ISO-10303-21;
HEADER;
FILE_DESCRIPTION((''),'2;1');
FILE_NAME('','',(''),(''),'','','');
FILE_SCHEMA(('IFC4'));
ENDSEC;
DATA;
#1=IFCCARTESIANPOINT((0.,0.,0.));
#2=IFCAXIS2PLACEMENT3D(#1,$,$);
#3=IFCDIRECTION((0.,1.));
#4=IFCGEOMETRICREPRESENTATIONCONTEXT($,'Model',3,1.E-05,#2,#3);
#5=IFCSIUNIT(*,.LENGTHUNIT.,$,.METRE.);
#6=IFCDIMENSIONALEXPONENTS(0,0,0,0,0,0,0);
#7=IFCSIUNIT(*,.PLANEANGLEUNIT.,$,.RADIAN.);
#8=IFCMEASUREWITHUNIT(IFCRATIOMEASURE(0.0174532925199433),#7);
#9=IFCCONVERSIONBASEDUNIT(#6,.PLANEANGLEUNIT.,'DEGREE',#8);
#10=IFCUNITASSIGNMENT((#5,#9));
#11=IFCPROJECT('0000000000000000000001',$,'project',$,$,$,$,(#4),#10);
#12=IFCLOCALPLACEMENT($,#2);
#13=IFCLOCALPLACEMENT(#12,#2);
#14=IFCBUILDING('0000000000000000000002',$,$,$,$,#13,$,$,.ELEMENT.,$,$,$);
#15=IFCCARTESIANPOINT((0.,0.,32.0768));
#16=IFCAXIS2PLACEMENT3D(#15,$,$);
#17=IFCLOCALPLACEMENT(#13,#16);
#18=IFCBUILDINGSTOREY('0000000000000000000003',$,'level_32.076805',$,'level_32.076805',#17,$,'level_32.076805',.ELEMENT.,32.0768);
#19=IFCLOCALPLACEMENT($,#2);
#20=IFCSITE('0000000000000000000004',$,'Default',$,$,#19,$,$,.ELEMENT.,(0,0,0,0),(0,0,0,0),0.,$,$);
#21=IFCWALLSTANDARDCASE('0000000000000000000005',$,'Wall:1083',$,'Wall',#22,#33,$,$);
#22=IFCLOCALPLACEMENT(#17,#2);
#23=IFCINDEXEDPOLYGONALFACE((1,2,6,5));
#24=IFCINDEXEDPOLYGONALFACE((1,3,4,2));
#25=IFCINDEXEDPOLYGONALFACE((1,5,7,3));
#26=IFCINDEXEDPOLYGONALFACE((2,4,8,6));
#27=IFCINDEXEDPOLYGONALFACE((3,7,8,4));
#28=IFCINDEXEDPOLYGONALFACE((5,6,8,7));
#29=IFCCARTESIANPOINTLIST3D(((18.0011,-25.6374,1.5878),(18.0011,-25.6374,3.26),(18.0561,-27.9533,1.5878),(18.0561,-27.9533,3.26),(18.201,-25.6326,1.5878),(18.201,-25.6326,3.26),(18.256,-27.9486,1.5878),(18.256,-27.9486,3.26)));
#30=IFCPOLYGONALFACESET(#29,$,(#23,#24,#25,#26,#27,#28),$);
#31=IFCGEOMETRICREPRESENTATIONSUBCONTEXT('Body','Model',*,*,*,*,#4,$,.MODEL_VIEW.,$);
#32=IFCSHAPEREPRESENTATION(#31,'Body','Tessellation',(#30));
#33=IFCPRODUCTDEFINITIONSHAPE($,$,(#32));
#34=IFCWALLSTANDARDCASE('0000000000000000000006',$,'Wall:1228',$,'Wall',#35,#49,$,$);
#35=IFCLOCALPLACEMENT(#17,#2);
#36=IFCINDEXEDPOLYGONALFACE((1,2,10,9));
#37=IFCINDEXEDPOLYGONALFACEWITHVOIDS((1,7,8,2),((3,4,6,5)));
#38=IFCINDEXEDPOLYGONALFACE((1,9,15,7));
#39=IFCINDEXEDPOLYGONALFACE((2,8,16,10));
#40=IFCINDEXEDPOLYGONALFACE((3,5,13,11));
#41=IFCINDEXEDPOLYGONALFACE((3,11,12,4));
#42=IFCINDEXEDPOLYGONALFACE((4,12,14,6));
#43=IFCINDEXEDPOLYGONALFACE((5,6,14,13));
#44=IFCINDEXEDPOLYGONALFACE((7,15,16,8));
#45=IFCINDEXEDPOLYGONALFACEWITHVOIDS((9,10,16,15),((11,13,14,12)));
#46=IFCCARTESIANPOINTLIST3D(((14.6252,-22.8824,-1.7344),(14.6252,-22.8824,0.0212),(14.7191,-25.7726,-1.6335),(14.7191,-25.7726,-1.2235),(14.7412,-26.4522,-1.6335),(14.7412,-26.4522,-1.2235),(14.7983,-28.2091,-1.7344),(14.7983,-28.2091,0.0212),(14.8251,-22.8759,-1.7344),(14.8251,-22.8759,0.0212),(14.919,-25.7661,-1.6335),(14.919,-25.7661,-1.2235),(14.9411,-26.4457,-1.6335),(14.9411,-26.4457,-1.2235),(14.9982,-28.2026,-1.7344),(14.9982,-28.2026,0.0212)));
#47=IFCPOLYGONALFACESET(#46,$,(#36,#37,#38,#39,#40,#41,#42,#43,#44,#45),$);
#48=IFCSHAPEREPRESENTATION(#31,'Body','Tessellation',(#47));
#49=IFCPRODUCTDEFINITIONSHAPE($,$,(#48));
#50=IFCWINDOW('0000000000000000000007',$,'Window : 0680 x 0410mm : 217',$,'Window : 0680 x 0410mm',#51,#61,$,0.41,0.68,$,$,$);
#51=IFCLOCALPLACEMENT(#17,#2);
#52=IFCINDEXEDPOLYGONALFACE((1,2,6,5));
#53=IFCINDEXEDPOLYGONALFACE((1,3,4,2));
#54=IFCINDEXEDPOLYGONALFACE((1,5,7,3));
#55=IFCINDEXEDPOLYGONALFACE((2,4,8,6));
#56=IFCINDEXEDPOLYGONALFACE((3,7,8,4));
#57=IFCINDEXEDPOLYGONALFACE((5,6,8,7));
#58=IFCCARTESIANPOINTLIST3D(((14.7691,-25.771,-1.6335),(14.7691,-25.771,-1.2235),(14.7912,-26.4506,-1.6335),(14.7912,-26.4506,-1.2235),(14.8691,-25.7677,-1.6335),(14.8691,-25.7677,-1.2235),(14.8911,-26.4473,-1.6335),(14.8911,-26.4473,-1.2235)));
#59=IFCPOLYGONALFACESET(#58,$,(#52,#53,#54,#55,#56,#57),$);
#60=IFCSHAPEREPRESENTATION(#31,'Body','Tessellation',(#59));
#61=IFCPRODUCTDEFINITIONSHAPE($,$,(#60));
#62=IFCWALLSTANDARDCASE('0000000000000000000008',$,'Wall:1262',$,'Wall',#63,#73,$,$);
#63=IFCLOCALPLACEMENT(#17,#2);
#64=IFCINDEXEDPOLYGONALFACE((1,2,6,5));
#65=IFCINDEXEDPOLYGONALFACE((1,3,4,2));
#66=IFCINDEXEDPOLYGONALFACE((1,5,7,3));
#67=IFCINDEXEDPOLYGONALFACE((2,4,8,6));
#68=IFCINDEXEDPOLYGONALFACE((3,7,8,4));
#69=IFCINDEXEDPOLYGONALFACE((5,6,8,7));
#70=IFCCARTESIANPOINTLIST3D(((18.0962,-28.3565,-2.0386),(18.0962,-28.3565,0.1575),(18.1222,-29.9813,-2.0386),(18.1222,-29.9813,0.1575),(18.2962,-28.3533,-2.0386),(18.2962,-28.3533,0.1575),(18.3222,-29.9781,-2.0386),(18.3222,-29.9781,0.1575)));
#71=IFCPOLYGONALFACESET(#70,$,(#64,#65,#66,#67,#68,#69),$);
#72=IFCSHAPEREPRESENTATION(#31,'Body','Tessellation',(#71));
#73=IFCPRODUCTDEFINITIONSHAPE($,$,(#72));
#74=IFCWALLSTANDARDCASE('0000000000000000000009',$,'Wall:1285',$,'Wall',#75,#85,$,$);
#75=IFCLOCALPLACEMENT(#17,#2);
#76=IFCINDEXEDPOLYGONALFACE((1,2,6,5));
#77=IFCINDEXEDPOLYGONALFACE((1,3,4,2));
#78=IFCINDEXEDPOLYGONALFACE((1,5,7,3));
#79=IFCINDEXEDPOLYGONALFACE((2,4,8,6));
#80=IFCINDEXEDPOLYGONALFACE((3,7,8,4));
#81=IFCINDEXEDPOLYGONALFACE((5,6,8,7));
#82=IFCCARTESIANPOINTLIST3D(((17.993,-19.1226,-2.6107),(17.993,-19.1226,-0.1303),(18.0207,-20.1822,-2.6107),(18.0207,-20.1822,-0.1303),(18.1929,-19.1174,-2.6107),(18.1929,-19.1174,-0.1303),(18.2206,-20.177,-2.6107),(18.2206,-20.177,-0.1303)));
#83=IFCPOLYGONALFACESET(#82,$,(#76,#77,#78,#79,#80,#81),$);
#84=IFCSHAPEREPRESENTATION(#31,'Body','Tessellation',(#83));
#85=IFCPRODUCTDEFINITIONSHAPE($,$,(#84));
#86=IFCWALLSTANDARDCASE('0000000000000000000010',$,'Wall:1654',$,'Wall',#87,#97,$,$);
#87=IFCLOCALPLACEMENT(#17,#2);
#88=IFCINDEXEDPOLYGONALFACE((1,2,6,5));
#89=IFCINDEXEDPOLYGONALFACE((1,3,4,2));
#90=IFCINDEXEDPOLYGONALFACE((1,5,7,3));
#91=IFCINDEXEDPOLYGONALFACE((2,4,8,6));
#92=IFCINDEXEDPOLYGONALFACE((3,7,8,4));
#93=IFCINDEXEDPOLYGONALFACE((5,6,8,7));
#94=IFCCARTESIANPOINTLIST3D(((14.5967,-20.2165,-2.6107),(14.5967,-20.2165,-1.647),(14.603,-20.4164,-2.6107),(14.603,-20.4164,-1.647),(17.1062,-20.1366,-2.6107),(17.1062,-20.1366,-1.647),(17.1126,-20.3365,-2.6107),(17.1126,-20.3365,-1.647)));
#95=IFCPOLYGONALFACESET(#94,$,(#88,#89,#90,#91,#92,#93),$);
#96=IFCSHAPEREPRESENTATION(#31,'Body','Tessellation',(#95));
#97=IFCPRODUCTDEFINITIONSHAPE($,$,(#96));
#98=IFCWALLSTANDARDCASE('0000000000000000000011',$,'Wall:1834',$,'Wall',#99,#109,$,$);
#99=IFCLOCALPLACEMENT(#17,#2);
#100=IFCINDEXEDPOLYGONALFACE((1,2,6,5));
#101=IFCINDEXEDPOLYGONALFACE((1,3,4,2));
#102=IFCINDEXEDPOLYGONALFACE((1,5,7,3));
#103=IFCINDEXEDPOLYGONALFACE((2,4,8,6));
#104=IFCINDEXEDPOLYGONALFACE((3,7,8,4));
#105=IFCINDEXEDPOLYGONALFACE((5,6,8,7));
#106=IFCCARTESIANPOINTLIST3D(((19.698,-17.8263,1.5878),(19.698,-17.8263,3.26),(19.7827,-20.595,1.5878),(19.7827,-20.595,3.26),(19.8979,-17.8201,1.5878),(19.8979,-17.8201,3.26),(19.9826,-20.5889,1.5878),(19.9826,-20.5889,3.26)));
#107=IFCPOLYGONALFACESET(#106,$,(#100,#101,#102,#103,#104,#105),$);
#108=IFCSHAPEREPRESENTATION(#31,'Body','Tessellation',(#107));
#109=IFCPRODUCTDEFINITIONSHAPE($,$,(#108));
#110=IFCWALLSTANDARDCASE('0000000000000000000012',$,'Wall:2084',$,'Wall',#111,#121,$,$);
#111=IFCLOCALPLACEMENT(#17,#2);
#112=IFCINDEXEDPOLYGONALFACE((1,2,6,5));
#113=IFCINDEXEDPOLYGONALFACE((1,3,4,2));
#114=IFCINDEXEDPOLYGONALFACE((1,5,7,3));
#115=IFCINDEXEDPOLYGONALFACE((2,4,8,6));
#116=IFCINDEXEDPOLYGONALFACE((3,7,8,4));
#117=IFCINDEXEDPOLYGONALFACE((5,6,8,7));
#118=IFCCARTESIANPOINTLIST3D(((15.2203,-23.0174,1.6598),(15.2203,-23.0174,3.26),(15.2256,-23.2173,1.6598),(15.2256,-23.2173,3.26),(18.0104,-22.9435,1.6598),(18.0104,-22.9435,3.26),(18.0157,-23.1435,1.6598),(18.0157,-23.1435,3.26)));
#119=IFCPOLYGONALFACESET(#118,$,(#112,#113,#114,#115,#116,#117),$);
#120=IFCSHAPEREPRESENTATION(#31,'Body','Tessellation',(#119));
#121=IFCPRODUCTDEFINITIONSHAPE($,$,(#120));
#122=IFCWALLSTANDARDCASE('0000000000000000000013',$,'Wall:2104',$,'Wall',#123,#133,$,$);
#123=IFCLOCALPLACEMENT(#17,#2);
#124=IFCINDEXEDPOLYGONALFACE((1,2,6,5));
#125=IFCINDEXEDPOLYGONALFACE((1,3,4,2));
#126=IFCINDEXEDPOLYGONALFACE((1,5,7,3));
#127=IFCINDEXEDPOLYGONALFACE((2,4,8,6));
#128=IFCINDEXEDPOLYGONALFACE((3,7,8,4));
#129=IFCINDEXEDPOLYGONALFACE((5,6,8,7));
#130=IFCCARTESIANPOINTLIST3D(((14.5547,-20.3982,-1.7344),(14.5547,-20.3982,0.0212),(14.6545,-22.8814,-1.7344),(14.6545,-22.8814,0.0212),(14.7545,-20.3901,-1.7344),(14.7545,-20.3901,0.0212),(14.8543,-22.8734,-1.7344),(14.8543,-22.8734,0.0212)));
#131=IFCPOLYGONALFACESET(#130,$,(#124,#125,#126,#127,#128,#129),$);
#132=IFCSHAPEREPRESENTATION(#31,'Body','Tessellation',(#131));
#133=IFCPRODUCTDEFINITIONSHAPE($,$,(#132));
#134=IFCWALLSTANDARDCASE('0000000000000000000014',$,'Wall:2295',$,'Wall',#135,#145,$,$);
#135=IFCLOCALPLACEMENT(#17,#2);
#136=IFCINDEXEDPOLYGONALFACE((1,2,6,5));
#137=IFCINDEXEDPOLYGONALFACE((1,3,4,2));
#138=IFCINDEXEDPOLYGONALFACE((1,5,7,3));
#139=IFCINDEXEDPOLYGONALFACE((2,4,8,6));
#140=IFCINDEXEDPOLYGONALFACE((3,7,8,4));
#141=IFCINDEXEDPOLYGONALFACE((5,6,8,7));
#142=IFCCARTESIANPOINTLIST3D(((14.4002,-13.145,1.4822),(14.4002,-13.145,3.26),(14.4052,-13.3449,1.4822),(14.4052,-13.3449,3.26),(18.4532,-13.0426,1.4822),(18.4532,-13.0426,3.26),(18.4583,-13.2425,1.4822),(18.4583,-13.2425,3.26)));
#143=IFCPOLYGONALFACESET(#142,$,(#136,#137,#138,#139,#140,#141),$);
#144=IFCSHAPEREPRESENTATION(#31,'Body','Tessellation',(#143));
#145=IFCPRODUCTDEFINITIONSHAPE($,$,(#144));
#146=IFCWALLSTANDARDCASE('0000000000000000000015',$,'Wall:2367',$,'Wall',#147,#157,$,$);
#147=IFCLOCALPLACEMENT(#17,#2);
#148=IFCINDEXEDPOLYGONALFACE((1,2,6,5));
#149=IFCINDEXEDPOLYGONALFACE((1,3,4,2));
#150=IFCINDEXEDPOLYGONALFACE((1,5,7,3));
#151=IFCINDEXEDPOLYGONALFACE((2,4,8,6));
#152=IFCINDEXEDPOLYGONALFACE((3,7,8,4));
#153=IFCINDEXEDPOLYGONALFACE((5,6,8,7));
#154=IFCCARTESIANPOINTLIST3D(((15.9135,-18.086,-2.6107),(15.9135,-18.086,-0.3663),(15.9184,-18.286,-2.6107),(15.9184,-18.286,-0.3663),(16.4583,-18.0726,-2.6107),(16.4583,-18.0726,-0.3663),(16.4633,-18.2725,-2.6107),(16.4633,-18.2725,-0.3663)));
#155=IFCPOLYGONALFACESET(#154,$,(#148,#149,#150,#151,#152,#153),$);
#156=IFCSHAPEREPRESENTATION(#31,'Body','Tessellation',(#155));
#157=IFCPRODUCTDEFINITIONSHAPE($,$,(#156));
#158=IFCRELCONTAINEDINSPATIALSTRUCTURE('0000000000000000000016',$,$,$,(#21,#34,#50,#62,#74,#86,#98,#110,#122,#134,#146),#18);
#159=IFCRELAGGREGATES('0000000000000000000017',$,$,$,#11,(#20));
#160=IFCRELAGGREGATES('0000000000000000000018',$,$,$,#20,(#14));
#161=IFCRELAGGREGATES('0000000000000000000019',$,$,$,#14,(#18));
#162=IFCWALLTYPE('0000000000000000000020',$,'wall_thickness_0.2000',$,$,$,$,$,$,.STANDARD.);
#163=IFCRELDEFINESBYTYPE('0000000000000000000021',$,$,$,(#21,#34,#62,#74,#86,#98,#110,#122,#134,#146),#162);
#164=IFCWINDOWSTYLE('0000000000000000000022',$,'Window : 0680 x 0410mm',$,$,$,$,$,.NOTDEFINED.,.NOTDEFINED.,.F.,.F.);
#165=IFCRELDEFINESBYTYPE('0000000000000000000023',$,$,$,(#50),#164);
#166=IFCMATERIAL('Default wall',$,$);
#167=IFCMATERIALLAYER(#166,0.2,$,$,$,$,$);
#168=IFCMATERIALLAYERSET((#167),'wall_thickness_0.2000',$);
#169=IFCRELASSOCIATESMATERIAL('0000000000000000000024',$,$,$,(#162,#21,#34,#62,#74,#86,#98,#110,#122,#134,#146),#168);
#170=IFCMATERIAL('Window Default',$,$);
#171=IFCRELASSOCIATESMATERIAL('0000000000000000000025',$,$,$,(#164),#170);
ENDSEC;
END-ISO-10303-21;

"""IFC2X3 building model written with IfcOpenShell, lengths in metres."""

from ifc_helpers import new_model, entity, si_unit, converted_unit, direction, frame, frame_2d, origin, origin_2d_with_axis, place, context, subcontext, project, spatial, polyline, rectangle, outline, extrude, source, transform, mapped, material, layer, layer_set, layer_usage, type_object, type_shapes, element, fill, save


model = new_model("IFC2X3")

# Units and contexts
model_context = context("Model", 3, precision=1e-05, world=origin(), true_north=direction((0.0, 1.0)))
body_context = subcontext(model_context, "Body", "Model", "MODEL_VIEW")
ifc_project = project(units=[si_unit("LENGTHUNIT", "METRE"), converted_unit("PLANEANGLEUNIT", "DEGREE", entity("IfcRatioMeasure", 0.0174532925199433), si_unit("PLANEANGLEUNIT", "RADIAN"), dimensions=[0, 0, 0, 0, 0, 0, 0])], contexts=[model_context])

# Site, building, storey
site_placement = place(None, origin())
site = spatial("IfcSite", under=ifc_project, at=site_placement, Name="Default", CompositionType="ELEMENT", RefLatitude=(0, 0, 0, 0), RefLongitude=(0, 0, 0, 0), RefElevation=0.0)
placement_1 = place(None, origin())
building_placement = place(placement_1, origin())
building = spatial("IfcBuilding", under=site, at=building_placement, CompositionType="ELEMENT")
storey_placement = place(building_placement, frame((0.0, 0.0, 32.0768)))
storey = spatial("IfcBuildingStorey", under=building, at=storey_placement, Name="level_32.076805", ObjectType="level_32.076805", LongName="level_32.076805", CompositionType="ELEMENT", Elevation=32.0768)

# Shared definitions
ifc_material_1 = material(Name="Default wall")
ifc_layer = layer(ifc_material_1, 0.2)
ifc_layer_set = layer_set([ifc_layer], Name="wall_thickness_0.2000")
ifc_layer_usage = layer_usage(ifc_layer_set, "AXIS2", "POSITIVE", -0.1)
wall_type = type_object("IfcWallType", Name="wall_thickness_0.2000", PredefinedType="STANDARD", material=ifc_layer_set)

# Shared definitions
ifc_material_2 = material(Name="Window Default")

# Wall
placement_2 = place(building_placement, frame((0.0, 0.0, 33.6646)))
wall_1_placement = place(placement_2, frame((18.156, -27.9509, 0.0), z_axis=(0.0, 0.0, 1.0), x_axis=(-0.02373, 0.999718, 0.0)))
element("IfcWallStandardCase", 1, at=wall_1_placement, inside=storey, type_object=wall_type, material=ifc_layer_usage, Name="Wall:1083", ObjectType="Wall", context=body_context, shape_type="SweptSolid", body=[
    extrude(outline(polyline([(2.3166, -0.1), (2.3166, 0.1), (0.0, 0.1), (0.0, -0.1), (2.3166, -0.1)])), origin(), (0.0, 0.0, 1.0), 1.6722),
])

# Wall, opening, window
placement_3 = place(building_placement, frame((0.0, 0.0, 30.3424)))
wall_2_placement = place(placement_3, frame((14.8983, -28.2059, 0.0), z_axis=(0.0, 0.0, 1.0), x_axis=(-0.032478, 0.999472, 0.0)))
wall_2 = element("IfcWallStandardCase", 2, at=wall_2_placement, inside=storey, type_object=wall_type, material=ifc_layer_usage, Name="Wall:1228", ObjectType="Wall", context=body_context, shape_type="SweptSolid", body=[
    extrude(outline(polyline([(5.3296, -0.1), (5.3296, 0.1), (0.0, 0.1), (0.0, -0.1), (5.3296, -0.1)])), origin(), (0.0, 0.0, 1.0), 1.7557),
])
opening_1_placement = place(wall_2_placement, frame((1.7578, -0.1, 0.1009)))
opening_1 = element("IfcOpeningElement", 3, at=opening_1_placement, cuts=wall_2, ObjectType="Opening", context=body_context, shape_type="SweptSolid", body=[
    extrude(rectangle(XDim=0.68, YDim=0.41, at=frame_2d((0.205, 0.34), x_axis=(0.0, 1.0))), frame((0.0, 0.0, 0.0), z_axis=(0.0, 1.0, 0.0), x_axis=(0.0, 0.0, 1.0)), (0.0, 0.0, 1.0), 0.2),
])
window_style_1 = type_object("IfcWindowStyle", Name="Window : 0680 x 0410mm", ConstructionType="NOTDEFINED", OperationType="NOTDEFINED", ParameterTakesPrecedence=False, Sizeable=False, material=ifc_material_2)
shared_shape_1 = source(origin(), body_context, "Body", "SweptSolid", [
    extrude(rectangle(XDim=0.1, YDim=0.68, at=origin_2d_with_axis()), frame((0.34, 0.1, 0.0), z_axis=(0.0, 0.0, 1.0), x_axis=(0.0, 1.0, 0.0)), (0.0, 0.0, 1.0), 0.41),
])
type_shapes(window_style_1, [shared_shape_1])
window_1_placement = place(opening_1_placement, origin())
window_1 = element("IfcWindow", 4, at=window_1_placement, inside=storey, type_object=window_style_1, Name="Window : 0680 x 0410mm : 217", ObjectType="Window : 0680 x 0410mm", OverallHeight=0.41, OverallWidth=0.68, context=body_context, shape_type="MappedRepresentation", body=[
    mapped(shared_shape_1, transform((0.0, 0.0, 0.0), scale=1.0)),
])
fill(opening_1, window_1)

# Walls
placement_4 = place(building_placement, frame((0.0, 0.0, 30.0382)))
wall_3_placement = place(placement_4, frame((18.2222, -29.9797, 0.0), z_axis=(0.0, 0.0, 1.0), x_axis=(-0.015997, 0.999872, 0.0)))
element("IfcWallStandardCase", 5, at=wall_3_placement, inside=storey, type_object=wall_type, material=ifc_layer_usage, Name="Wall:1262", ObjectType="Wall", context=body_context, shape_type="SweptSolid", body=[
    extrude(outline(polyline([(1.625, -0.1), (1.625, 0.1), (0.0, 0.1), (0.0, -0.1), (1.625, -0.1)])), origin(), (0.0, 0.0, 1.0), 2.1961),
])
placement_5 = place(building_placement, frame((0.0, 0.0, 29.4661)))
wall_4_placement = place(placement_5, frame((18.0929, -19.12, 0.0), z_axis=(0.0, 0.0, 1.0), x_axis=(0.026143, -0.999658, 0.0)))
element("IfcWallStandardCase", 6, at=wall_4_placement, inside=storey, type_object=wall_type, material=ifc_layer_usage, Name="Wall:1285", ObjectType="Wall", context=body_context, shape_type="SweptSolid", body=[
    extrude(outline(polyline([(1.06, -0.1), (1.06, 0.1), (0.0, 0.1), (0.0, -0.1), (1.06, -0.1)])), origin(), (0.0, 0.0, 1.0), 2.4805),
])
placement_6 = place(building_placement, frame((0.0, 0.0, 29.4661)))
wall_5_placement = place(placement_6, frame((14.5999, -20.3165, 0.0), z_axis=(0.0, 0.0, 1.0), x_axis=(0.999494, 0.031811, 0.0)))
element("IfcWallStandardCase", 7, at=wall_5_placement, inside=storey, type_object=wall_type, material=ifc_layer_usage, Name="Wall:1654", ObjectType="Wall", context=body_context, shape_type="SweptSolid", body=[
    extrude(outline(polyline([(2.5108, -0.1), (2.5108, 0.1), (0.0, 0.1), (0.0, -0.1), (2.5108, -0.1)])), origin(), (0.0, 0.0, 1.0), 0.9637),
])
placement_7 = place(building_placement, frame((0.0, 0.0, 33.6646)))
wall_6_placement = place(placement_7, frame((19.8826, -20.5919, 0.0), z_axis=(0.0, 0.0, 1.0), x_axis=(-0.030577, 0.999532, 0.0)))
element("IfcWallStandardCase", 8, at=wall_6_placement, inside=storey, type_object=wall_type, material=ifc_layer_usage, Name="Wall:1834", ObjectType="Wall", context=body_context, shape_type="SweptSolid", body=[
    extrude(outline(polyline([(2.77, -0.1), (2.77, 0.1), (0.0, 0.1), (0.0, -0.1), (2.77, -0.1)])), origin(), (0.0, 0.0, 1.0), 1.6722),
])
placement_8 = place(building_placement, frame((0.0, 0.0, 33.7366)))
wall_7_placement = place(placement_8, frame((15.223, -23.1174, 0.0), z_axis=(0.0, 0.0, 1.0), x_axis=(0.99965, 0.02646, 0.0)))
element("IfcWallStandardCase", 9, at=wall_7_placement, inside=storey, type_object=wall_type, material=ifc_layer_usage, Name="Wall:2084", ObjectType="Wall", context=body_context, shape_type="SweptSolid", body=[
    extrude(outline(polyline([(2.791, -0.1), (2.791, 0.1), (0.0, 0.1), (0.0, -0.1), (2.791, -0.1)])), origin(), (0.0, 0.0, 1.0), 1.6002),
])
placement_9 = place(building_placement, frame((0.0, 0.0, 30.3424)))
wall_8_placement = place(placement_9, frame((14.7544, -22.8774, 0.0), z_axis=(0.0, 0.0, 1.0), x_axis=(-0.040147, 0.999194, 0.0)))
element("IfcWallStandardCase", 10, at=wall_8_placement, inside=storey, type_object=wall_type, material=ifc_layer_usage, Name="Wall:2104", ObjectType="Wall", context=body_context, shape_type="SweptSolid", body=[
    extrude(outline(polyline([(2.4853, -0.1), (2.4853, 0.1), (0.0, 0.1), (0.0, -0.1), (2.4853, -0.1)])), origin(), (0.0, 0.0, 1.0), 1.7557),
])
placement_10 = place(building_placement, frame((0.0, 0.0, 33.559)))
wall_9_placement = place(placement_10, frame((14.4027, -13.245, 0.0), z_axis=(0.0, 0.0, 1.0), x_axis=(0.999681, 0.025268, 0.0)))
element("IfcWallStandardCase", 11, at=wall_9_placement, inside=storey, type_object=wall_type, material=ifc_layer_usage, Name="Wall:2295", ObjectType="Wall", context=body_context, shape_type="SweptSolid", body=[
    extrude(outline(polyline([(4.0543, -0.1), (4.0543, 0.1), (0.0, 0.1), (0.0, -0.1), (4.0543, -0.1)])), origin(), (0.0, 0.0, 1.0), 1.7778),
])
placement_11 = place(building_placement, frame((0.0, 0.0, 29.4661)))
wall_10_placement = place(placement_11, frame((16.4608, -18.1725, 0.0), z_axis=(0.0, 0.0, 1.0), x_axis=(-0.999695, -0.024698, 0.0)))
element("IfcWallStandardCase", 12, at=wall_10_placement, inside=storey, type_object=wall_type, material=ifc_layer_usage, Name="Wall:2367", ObjectType="Wall", context=body_context, shape_type="SweptSolid", body=[
    extrude(outline(polyline([(0.545, -0.1), (0.545, 0.1), (0.0, 0.1), (0.0, -0.1), (0.545, -0.1)])), origin(), (0.0, 0.0, 1.0), 2.2444),
])

save(model, "model.ifc")
